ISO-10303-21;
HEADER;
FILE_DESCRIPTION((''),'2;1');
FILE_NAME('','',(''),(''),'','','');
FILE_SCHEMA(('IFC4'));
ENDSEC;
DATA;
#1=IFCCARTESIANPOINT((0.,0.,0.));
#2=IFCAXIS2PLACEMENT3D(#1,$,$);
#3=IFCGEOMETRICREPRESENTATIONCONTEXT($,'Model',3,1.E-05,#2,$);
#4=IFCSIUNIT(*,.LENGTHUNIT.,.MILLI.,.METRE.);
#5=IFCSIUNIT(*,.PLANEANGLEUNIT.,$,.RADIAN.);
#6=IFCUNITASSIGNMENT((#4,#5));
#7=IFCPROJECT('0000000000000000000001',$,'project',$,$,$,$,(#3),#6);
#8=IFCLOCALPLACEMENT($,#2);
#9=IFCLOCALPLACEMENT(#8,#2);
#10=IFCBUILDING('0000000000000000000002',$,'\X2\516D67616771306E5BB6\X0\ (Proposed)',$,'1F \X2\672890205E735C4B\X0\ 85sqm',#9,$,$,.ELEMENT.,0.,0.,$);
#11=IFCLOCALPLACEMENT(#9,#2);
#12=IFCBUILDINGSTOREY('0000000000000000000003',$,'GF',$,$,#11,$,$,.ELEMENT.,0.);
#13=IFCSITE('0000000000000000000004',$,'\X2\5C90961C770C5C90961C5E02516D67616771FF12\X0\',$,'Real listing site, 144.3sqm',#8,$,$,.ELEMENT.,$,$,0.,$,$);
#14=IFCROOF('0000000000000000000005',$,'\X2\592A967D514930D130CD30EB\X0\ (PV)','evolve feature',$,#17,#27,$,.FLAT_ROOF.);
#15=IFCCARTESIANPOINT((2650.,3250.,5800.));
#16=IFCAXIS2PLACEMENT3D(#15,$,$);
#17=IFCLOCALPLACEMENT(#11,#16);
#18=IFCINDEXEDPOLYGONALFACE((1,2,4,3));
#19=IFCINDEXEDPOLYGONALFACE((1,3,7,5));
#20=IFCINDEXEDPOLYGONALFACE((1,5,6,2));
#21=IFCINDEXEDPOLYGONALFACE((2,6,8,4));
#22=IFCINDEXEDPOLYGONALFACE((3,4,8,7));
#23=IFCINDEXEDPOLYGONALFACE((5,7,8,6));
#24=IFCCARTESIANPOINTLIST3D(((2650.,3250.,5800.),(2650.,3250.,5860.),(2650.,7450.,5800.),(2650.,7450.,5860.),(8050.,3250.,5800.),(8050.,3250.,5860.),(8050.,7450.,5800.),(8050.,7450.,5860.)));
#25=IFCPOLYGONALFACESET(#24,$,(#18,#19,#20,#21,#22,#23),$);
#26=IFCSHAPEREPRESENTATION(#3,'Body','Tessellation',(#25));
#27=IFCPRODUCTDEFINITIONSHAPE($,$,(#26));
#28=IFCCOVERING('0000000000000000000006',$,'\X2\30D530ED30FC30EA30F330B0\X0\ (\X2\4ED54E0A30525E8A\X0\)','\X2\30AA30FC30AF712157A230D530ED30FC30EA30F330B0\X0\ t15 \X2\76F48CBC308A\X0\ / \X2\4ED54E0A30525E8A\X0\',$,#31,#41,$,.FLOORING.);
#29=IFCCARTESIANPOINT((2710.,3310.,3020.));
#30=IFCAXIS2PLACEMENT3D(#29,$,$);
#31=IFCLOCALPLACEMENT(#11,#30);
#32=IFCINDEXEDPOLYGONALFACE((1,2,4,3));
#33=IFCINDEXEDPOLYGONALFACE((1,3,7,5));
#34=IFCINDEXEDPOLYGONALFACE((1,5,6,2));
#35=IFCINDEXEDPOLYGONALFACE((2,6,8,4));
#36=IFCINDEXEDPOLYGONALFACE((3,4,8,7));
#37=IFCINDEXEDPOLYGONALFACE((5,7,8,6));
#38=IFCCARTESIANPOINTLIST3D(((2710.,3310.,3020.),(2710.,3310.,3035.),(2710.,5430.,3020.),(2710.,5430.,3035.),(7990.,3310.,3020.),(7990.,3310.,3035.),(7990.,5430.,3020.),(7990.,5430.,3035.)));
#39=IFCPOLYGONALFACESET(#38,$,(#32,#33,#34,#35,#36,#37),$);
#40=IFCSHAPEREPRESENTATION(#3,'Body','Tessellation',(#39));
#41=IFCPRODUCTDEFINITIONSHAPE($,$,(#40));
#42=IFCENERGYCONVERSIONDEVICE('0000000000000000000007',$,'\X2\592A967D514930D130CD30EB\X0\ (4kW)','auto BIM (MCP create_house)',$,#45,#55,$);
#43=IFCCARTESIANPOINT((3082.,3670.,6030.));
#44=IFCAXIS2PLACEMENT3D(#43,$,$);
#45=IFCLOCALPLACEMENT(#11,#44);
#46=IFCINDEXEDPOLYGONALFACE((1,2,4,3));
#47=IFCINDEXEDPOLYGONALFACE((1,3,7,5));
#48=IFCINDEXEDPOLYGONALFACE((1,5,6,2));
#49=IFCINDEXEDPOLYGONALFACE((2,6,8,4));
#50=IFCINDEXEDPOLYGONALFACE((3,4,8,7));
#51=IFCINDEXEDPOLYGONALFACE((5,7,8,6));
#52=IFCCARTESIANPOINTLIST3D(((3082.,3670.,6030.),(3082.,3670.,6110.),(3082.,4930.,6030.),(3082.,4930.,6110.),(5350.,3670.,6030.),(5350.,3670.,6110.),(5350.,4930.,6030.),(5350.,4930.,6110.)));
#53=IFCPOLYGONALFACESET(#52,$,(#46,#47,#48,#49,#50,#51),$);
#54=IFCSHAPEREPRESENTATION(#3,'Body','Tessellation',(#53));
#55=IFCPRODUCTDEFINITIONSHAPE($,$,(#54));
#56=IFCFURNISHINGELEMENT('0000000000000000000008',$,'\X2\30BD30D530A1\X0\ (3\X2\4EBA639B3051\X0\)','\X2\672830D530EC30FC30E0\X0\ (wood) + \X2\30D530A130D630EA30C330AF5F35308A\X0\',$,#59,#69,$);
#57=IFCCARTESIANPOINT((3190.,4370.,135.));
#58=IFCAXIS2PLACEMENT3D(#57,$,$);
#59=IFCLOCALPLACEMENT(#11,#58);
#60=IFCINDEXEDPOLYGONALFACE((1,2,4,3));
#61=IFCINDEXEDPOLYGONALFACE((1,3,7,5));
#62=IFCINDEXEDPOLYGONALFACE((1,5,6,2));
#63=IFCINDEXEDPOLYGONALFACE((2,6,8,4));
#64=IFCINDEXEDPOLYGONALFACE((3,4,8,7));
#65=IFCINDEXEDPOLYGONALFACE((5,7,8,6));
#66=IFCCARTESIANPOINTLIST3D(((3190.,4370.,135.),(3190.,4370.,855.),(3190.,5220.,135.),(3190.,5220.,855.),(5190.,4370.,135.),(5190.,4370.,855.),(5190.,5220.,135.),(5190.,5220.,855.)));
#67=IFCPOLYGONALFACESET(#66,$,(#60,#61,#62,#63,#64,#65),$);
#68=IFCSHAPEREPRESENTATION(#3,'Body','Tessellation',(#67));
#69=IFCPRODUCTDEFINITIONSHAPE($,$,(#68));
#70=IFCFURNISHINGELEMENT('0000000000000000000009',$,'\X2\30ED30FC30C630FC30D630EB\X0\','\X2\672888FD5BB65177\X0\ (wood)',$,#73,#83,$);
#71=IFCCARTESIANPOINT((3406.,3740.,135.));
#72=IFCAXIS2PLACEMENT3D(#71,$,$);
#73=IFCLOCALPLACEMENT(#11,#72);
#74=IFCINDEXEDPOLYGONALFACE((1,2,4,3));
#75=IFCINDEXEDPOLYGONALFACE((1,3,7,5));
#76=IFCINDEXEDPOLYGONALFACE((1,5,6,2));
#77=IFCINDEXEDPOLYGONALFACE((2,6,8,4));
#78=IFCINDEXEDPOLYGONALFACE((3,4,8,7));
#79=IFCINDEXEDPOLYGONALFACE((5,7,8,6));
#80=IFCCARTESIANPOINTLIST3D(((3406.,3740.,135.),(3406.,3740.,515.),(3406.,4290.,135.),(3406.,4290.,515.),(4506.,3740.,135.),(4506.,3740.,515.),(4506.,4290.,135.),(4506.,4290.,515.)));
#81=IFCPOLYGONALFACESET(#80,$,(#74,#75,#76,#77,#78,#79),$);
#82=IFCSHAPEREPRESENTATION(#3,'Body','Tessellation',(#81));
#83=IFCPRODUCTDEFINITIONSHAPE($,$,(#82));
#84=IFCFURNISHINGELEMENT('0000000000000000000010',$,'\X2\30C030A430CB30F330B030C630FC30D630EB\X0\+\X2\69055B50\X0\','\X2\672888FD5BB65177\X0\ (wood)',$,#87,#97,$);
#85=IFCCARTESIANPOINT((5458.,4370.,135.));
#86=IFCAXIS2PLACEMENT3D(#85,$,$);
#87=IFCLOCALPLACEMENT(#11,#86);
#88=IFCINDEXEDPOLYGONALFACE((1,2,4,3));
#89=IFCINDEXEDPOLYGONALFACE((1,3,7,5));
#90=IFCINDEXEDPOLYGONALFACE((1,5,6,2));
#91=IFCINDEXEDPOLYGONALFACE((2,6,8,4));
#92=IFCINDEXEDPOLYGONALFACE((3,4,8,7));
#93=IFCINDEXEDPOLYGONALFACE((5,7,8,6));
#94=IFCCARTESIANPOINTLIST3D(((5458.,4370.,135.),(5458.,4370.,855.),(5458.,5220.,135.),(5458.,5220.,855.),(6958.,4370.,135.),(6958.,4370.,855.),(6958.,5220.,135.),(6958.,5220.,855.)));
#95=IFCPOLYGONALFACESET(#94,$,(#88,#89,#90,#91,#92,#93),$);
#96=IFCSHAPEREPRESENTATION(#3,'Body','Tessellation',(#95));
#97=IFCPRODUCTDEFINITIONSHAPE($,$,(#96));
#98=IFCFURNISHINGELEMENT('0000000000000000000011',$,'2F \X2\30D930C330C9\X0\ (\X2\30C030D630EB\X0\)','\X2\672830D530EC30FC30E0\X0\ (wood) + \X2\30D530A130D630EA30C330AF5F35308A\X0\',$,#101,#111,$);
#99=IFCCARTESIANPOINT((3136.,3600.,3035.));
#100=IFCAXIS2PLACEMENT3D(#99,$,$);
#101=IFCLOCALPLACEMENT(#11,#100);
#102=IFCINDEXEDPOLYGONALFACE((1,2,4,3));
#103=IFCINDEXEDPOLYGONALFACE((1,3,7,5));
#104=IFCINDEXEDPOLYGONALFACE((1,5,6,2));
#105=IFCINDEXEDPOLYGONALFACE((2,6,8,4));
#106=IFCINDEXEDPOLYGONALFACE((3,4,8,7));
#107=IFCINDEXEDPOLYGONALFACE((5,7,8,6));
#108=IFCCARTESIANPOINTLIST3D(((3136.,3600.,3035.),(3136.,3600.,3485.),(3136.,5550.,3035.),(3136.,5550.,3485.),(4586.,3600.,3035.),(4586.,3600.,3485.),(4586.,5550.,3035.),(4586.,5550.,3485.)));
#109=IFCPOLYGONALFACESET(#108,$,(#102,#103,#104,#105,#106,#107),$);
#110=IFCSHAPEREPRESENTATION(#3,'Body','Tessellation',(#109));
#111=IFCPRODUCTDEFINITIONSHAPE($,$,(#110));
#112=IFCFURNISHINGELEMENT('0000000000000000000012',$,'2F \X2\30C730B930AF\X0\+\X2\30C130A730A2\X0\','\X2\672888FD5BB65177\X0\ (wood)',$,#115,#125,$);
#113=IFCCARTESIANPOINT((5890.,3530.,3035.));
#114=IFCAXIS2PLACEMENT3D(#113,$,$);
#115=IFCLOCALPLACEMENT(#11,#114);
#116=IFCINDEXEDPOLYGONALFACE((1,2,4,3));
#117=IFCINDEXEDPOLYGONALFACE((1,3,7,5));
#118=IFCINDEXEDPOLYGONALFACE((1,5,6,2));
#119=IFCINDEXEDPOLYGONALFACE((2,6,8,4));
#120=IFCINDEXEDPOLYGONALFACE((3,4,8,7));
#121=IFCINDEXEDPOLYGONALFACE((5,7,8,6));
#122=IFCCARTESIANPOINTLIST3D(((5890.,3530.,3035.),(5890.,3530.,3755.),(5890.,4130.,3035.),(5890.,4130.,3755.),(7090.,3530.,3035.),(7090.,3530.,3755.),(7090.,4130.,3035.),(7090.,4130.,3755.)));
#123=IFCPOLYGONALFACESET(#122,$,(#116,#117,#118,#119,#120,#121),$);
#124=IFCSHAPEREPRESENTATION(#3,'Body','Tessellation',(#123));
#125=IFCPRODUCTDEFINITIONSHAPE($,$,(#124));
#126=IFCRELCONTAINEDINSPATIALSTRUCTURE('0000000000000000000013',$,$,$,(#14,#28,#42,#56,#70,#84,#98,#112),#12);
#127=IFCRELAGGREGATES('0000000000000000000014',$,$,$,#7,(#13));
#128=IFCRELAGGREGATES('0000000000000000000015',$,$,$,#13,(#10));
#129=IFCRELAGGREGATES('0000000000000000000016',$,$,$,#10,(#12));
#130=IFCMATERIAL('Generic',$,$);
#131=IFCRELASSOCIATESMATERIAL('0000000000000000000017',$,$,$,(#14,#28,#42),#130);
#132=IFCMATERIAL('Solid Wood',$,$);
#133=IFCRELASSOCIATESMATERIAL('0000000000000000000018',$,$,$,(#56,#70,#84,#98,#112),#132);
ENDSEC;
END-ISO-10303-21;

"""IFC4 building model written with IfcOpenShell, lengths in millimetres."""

from ifc_helpers import new_model, si_unit, frame, frame_2d, origin, place, context, project, spatial, rectangle, extrude, material, element, save


model = new_model("IFC4")

# Units and contexts
model_context = context("Model", 3, precision=1e-05, world=origin())
ifc_project = project(units=[si_unit("LENGTHUNIT", "METRE", prefix="MILLI"), si_unit("PLANEANGLEUNIT", "RADIAN")], contexts=[model_context])

# Site, building, storey
site_placement = place(None, origin())
site = spatial("IfcSite", under=ifc_project, at=site_placement, Name="岐阜県岐阜市六条東２", ObjectType="Real listing site, 144.3sqm", CompositionType="ELEMENT", RefElevation=0.0)
building_placement = place(site_placement, origin())
building = spatial("IfcBuilding", under=site, at=building_placement, Name="六条東の家 (Proposed)", ObjectType="1F 木造平屋 85sqm", CompositionType="ELEMENT", ElevationOfRefHeight=0.0, ElevationOfTerrain=0.0)
storey_placement = place(building_placement, origin())
storey = spatial("IfcBuildingStorey", under=building, at=storey_placement, Name="GF", CompositionType="ELEMENT", Elevation=0.0)

# Shared definitions
ifc_material_1 = material(Name="Solid Wood")

# Roof
ifc_material_2 = material(Name="Generic")
roof_1_placement = place(storey_placement, frame((2650.0, 3250.0, 5800.0)))
element("IfcRoof", 1, at=roof_1_placement, inside=storey, material=ifc_material_2, Name="太陽光パネル (PV)", Description="evolve feature", PredefinedType="FLAT_ROOF", context=model_context, shape_type="SweptSolid", body=[
    extrude(rectangle(XDim=5400.0, YDim=4200.0, at=frame_2d((2700.0, 2100.0))), frame((2650.0, 3250.0, 5800.0)), (0.0, 0.0, 1.0), 60.0),
])

# Covering
covering_placement = place(storey_placement, frame((2710.0, 3310.0, 3020.0)))
element("IfcCovering", 2, at=covering_placement, inside=storey, material=ifc_material_2, Name="フローリング (仕上げ床)", Description="オーク無垢フローリング t15 直貼り / 仕上げ床", PredefinedType="FLOORING", context=model_context, shape_type="SweptSolid", body=[
    extrude(rectangle(XDim=5280.0, YDim=2120.0, at=frame_2d((2640.0, 1060.0))), frame((2710.0, 3310.0, 3020.0)), (0.0, 0.0, 1.0), 15.0),
])

# Energy conversion device
energy_conversion_device_placement = place(storey_placement, frame((3082.0, 3670.0, 6030.0)))
element("IfcEnergyConversionDevice", 3, at=energy_conversion_device_placement, inside=storey, material=ifc_material_2, Name="太陽光パネル (4kW)", Description="auto BIM (MCP create_house)", context=model_context, shape_type="SweptSolid", body=[
    extrude(rectangle(XDim=2268.0, YDim=1260.0, at=frame_2d((1134.0, 630.0))), frame((3082.0, 3670.0, 6030.0)), (0.0, 0.0, 1.0), 80.0),
])

# Furnishing elements
furnishing_1_placement = place(storey_placement, frame((3190.0, 4370.0, 135.0)))
element("IfcFurnishingElement", 4, at=furnishing_1_placement, inside=storey, material=ifc_material_1, Name="ソファ (3人掛け)", Description="木フレーム (wood) + ファブリック張り", context=model_context, shape_type="SweptSolid", body=[
    extrude(rectangle(XDim=2000.0, YDim=850.0, at=frame_2d((1000.0, 425.0))), frame((3190.0, 4370.0, 135.0)), (0.0, 0.0, 1.0), 720.0),
])
furnishing_2_placement = place(storey_placement, frame((3406.0, 3740.0, 135.0)))
element("IfcFurnishingElement", 5, at=furnishing_2_placement, inside=storey, material=ifc_material_1, Name="ローテーブル", Description="木製家具 (wood)", context=model_context, shape_type="SweptSolid", body=[
    extrude(rectangle(XDim=1100.0, YDim=550.0, at=frame_2d((550.0, 275.0))), frame((3406.0, 3740.0, 135.0)), (0.0, 0.0, 1.0), 380.0),
])
furnishing_3_placement = place(storey_placement, frame((5458.0, 4370.0, 135.0)))
element("IfcFurnishingElement", 6, at=furnishing_3_placement, inside=storey, material=ifc_material_1, Name="ダイニングテーブル+椅子", Description="木製家具 (wood)", context=model_context, shape_type="SweptSolid", body=[
    extrude(rectangle(XDim=1500.0, YDim=850.0, at=frame_2d((750.0, 425.0))), frame((5458.0, 4370.0, 135.0)), (0.0, 0.0, 1.0), 720.0),
])
furnishing_4_placement = place(storey_placement, frame((3136.0, 3600.0, 3035.0)))
element("IfcFurnishingElement", 7, at=furnishing_4_placement, inside=storey, material=ifc_material_1, Name="2F ベッド (ダブル)", Description="木フレーム (wood) + ファブリック張り", context=model_context, shape_type="SweptSolid", body=[
    extrude(rectangle(XDim=1450.0, YDim=1950.0, at=frame_2d((725.0, 975.0))), frame((3136.0, 3600.0, 3035.0)), (0.0, 0.0, 1.0), 450.0),
])
furnishing_5_placement = place(storey_placement, frame((5890.0, 3530.0, 3035.0)))
element("IfcFurnishingElement", 8, at=furnishing_5_placement, inside=storey, material=ifc_material_1, Name="2F デスク+チェア", Description="木製家具 (wood)", context=model_context, shape_type="SweptSolid", body=[
    extrude(rectangle(XDim=1200.0, YDim=600.0, at=frame_2d((600.0, 300.0))), frame((5890.0, 3530.0, 3035.0)), (0.0, 0.0, 1.0), 720.0),
])

save(model, "model.ifc")
